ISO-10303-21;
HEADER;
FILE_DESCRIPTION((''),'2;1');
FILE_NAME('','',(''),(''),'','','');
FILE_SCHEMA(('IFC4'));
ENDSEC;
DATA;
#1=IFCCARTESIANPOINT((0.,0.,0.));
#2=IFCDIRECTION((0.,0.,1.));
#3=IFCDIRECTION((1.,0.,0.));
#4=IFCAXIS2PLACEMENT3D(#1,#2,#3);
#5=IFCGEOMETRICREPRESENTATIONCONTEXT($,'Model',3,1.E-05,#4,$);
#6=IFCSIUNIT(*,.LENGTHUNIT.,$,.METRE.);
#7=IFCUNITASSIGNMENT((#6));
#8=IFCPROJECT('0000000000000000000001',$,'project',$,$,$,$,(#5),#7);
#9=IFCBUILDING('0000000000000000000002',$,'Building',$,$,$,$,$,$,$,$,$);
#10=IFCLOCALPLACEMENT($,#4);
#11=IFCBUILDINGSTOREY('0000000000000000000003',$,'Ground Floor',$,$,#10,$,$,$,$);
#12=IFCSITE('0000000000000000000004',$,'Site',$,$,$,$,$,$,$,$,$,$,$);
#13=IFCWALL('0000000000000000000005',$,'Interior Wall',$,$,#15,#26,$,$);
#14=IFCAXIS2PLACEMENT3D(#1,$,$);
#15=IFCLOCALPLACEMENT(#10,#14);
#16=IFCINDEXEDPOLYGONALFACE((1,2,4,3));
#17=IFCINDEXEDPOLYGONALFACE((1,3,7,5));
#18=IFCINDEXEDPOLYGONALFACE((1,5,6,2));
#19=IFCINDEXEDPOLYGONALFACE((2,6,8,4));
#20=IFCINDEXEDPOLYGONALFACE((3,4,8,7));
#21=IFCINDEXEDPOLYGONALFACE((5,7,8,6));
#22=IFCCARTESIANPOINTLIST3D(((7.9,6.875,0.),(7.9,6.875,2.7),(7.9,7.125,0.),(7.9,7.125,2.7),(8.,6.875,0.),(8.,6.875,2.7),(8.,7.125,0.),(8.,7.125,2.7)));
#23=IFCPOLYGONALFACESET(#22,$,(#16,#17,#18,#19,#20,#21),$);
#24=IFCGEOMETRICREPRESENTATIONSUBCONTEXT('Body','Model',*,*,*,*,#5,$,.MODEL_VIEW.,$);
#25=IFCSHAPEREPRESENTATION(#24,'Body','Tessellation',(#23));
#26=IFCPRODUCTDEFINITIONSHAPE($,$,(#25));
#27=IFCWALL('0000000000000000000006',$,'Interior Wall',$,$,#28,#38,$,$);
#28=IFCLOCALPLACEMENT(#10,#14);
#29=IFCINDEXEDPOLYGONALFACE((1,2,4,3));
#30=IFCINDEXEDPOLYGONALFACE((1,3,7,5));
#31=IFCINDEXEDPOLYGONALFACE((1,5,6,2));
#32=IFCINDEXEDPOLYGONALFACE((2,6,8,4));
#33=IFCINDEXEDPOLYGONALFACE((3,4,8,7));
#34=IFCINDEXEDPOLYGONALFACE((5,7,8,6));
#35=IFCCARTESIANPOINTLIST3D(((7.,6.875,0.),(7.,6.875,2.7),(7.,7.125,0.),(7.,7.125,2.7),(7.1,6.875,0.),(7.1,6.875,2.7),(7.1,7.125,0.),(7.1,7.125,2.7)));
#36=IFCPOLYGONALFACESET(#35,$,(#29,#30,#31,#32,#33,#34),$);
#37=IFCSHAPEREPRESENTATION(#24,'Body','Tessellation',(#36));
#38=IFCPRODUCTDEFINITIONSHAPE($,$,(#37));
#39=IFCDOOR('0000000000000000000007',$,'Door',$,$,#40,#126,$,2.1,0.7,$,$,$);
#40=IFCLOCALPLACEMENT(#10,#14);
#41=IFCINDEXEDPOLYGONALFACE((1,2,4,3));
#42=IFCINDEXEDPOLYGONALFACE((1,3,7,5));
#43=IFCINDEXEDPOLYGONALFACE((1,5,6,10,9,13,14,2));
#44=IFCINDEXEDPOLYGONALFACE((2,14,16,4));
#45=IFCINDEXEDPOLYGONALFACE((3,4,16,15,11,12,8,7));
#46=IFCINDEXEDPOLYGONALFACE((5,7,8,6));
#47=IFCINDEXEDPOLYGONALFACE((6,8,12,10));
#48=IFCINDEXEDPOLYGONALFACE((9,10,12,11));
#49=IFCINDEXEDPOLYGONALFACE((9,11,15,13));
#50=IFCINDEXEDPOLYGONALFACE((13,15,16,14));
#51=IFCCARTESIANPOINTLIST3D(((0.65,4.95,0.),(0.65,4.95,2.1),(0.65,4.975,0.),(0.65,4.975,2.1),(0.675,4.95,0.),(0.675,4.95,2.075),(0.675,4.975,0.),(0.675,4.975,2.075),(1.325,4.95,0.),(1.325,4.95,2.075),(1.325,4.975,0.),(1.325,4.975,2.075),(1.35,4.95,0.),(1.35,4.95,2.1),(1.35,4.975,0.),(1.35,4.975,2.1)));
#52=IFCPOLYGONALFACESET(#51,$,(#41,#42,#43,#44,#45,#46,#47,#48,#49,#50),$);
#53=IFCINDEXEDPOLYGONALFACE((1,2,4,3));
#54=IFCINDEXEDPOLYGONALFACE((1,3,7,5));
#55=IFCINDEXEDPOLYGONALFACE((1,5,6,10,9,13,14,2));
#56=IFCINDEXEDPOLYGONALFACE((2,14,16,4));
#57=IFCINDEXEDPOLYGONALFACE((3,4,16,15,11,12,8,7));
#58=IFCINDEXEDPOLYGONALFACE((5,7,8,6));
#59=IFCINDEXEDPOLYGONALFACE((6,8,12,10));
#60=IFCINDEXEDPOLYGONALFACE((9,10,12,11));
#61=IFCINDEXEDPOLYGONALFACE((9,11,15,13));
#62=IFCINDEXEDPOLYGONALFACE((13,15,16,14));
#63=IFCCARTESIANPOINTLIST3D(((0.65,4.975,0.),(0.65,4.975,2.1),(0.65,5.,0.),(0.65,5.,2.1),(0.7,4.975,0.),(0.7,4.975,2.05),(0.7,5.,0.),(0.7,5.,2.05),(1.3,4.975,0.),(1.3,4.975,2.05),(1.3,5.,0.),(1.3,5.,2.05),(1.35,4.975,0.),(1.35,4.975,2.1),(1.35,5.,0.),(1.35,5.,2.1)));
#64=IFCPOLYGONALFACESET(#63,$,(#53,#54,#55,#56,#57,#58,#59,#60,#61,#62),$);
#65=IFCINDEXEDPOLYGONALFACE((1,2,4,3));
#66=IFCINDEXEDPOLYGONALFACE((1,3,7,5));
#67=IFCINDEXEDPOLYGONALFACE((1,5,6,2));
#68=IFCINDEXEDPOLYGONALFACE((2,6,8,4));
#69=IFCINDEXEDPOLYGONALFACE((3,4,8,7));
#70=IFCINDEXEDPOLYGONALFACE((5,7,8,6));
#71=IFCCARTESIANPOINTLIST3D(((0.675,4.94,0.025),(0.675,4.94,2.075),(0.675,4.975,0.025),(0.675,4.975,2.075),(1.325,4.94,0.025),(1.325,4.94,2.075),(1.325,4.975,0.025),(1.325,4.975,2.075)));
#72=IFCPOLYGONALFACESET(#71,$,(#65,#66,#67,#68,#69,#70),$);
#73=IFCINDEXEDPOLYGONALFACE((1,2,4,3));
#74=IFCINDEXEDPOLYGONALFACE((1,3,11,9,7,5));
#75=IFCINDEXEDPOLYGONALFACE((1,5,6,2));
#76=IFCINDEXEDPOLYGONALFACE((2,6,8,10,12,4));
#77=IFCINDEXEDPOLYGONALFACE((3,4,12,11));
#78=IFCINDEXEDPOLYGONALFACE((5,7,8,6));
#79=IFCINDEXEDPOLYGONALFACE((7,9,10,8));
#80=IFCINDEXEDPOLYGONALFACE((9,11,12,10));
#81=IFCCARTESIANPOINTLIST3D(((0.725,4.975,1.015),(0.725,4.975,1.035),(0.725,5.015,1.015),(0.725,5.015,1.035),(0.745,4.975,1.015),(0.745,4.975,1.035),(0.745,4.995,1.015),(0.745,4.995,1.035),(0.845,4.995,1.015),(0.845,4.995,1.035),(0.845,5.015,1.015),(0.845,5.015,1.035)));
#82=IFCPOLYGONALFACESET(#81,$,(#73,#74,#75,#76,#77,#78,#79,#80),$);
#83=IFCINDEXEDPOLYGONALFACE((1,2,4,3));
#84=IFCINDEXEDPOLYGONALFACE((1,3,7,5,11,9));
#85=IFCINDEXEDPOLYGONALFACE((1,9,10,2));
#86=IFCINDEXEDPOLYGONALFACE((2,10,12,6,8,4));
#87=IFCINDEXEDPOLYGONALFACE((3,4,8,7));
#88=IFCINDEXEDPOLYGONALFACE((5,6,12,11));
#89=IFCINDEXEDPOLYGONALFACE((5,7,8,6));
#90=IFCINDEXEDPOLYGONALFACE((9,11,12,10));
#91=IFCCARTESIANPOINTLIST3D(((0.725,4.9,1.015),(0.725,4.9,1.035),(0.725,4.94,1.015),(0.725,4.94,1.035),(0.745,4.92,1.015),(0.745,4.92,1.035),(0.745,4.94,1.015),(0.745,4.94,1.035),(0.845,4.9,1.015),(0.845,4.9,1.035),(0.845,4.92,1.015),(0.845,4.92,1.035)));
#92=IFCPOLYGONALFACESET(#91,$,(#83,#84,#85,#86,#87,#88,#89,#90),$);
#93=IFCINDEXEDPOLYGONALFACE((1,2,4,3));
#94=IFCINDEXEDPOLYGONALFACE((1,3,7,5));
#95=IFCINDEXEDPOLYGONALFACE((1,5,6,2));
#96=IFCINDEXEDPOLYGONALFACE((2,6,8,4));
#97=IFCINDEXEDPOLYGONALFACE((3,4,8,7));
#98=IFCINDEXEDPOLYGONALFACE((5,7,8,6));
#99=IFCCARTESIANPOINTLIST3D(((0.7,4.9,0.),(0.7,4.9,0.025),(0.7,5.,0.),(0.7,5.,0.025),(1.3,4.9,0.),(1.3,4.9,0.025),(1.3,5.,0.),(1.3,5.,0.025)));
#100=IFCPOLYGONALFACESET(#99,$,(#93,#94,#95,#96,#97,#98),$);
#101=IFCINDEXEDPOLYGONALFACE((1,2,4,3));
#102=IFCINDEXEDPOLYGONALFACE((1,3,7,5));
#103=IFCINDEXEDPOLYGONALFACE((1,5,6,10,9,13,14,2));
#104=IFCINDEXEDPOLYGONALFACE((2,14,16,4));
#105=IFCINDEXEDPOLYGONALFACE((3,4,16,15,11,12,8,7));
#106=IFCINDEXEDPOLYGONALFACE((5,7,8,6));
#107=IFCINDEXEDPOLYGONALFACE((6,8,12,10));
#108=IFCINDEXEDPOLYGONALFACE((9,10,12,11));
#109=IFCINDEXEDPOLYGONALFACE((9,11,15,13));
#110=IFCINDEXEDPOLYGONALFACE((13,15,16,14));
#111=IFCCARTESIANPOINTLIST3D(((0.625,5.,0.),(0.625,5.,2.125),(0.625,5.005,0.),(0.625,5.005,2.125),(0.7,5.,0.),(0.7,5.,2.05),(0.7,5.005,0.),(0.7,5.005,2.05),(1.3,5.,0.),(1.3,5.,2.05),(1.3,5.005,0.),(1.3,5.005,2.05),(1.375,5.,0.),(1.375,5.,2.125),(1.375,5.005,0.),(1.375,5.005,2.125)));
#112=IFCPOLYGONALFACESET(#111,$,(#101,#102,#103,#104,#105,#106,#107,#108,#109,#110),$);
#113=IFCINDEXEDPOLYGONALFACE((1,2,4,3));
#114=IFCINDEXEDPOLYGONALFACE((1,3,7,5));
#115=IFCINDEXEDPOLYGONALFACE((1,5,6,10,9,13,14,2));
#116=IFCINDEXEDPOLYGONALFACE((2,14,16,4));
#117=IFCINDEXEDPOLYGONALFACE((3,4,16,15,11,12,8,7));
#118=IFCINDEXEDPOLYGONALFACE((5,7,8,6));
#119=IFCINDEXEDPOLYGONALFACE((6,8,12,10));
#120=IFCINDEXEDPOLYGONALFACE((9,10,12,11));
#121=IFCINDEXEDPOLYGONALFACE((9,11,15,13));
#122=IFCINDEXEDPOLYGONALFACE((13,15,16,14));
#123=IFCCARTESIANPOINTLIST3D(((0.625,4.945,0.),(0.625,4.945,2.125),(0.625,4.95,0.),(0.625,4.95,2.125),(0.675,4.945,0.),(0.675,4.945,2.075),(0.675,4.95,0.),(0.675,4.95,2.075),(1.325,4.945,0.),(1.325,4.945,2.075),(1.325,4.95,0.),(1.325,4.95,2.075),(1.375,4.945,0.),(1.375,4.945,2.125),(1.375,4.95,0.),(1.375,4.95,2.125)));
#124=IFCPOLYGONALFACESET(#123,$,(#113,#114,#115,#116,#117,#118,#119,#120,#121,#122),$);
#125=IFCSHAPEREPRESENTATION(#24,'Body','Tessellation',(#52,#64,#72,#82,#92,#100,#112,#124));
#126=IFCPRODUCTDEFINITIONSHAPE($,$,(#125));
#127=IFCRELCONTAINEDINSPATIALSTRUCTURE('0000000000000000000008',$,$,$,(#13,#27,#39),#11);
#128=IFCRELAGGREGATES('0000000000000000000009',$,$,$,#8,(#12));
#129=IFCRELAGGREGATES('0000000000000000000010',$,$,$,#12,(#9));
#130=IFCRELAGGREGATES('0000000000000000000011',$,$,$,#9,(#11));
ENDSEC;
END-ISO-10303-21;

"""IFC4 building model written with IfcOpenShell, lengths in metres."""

from ifc_helpers import new_model, si_unit, frame, origin_with_axes, place, context, subcontext, project, spatial, line, indexed_curve, outline, extrude, element, save


model = new_model("IFC4")

# Units and contexts
model_context = context("Model", 3, precision=1e-05, world=origin_with_axes())
body_context = subcontext(model_context, "Body", "Model", "MODEL_VIEW")
ifc_project = project(units=[si_unit("LENGTHUNIT", "METRE")], contexts=[model_context])

# Site, building, storey
site = spatial("IfcSite", under=ifc_project, Name="Site")
building = spatial("IfcBuilding", under=site, Name="Building")
storey_placement = place(None, origin_with_axes())
storey = spatial("IfcBuildingStorey", under=building, at=storey_placement, Name="Ground Floor")

# Walls
for number, where, z_axis, x_axis, name in (
    (1, (8.0, 7.0, 0.0), (0.0, 0.0, 1.0), (-1.0, 0.0, 0.0), "Interior Wall"),
    (2, (7.1, 7.0, 0.0), (0.0, 0.0, 1.0), (-1.0, 0.0, 0.0), "Interior Wall"),
):
    element("IfcWall", number, at=place(storey_placement, frame(where, z_axis=z_axis, x_axis=x_axis)), inside=storey, Name=name, context=body_context, shape_type="SweptSolid", body=[
        extrude(outline(indexed_curve([(0.0, 0.0), (0.0, 0.25), (0.1, 0.25), (0.1, 0.0), (0.0, 0.0)], self_intersect=False)), frame((0.0, -0.125, 0.0), z_axis=(0.0, 0.0, 1.0), x_axis=(1.0, 0.0, 0.0)), (0.0, 0.0, 1.0), 2.7),
    ])

# Door
door_1_placement = place(storey_placement, frame((1.35, 5.0, 0.0), z_axis=(0.0, 0.0, 1.0), x_axis=(-1.0, 0.0, 0.0)))
element("IfcDoor", 3, at=door_1_placement, inside=storey, Name="Door", OverallHeight=2.1, OverallWidth=0.7, context=body_context, shape_type="SweptSolid", body=[
    extrude(outline(indexed_curve([(0.0, 0.0), (0.0, 2.1), (0.7, 2.1), (0.7, 0.0), (0.675, 0.0), (0.675, 2.075), (0.025, 2.075), (0.025, 0.0)], segments=[line(1, 2, 3, 4, 5, 6, 7, 8, 1)])), frame((0.0, 0.025, 0.0), z_axis=(0.0, -1.0, 0.0), x_axis=(1.0, 0.0, 0.0)), (0.0, 0.0, -1.0), 0.025),
    extrude(outline(indexed_curve([(0.0, 0.0), (0.0, 2.1), (0.7, 2.1), (0.7, 0.0), (0.65, 0.0), (0.65, 2.05), (0.05, 2.05), (0.05, 0.0)], segments=[line(1, 2, 3, 4, 5, 6, 7, 8, 1)])), frame((0.0, 0.0, 0.0), z_axis=(0.0, -1.0, 0.0), x_axis=(1.0, 0.0, 0.0)), (0.0, 0.0, -1.0), 0.025),
    extrude(outline(indexed_curve([(0.0, 0.0), (0.65, 0.0), (0.65, 0.035), (0.0, 0.035)], segments=[line(1, 2, 3, 4, 1)])), frame((0.025, 0.025, 0.025), z_axis=(0.0, 0.0, 1.0), x_axis=(1.0, 0.0, 0.0)), (0.0, 0.0, 1.0), 2.05),
    extrude(outline(indexed_curve([(0.0, 0.0), (0.0, -0.04), (-0.12, -0.04), (-0.12, -0.02), (-0.02, -0.02), (-0.02, 0.0)], segments=[line(1, 2, 3, 4, 5, 6, 1)])), frame((0.625, 0.025, 1.015), z_axis=(0.0, 0.0, 1.0), x_axis=(1.0, 0.0, 0.0)), (0.0, 0.0, 1.0), 0.02),
    extrude(outline(indexed_curve([(0.0, 0.0), (0.0, 0.04), (-0.12, 0.04), (-0.12, 0.02), (-0.02, 0.02), (-0.02, 0.0)], segments=[line(1, 2, 3, 4, 5, 6, 1)])), frame((0.625, 0.06, 1.015), z_axis=(0.0, 0.0, 1.0), x_axis=(1.0, 0.0, 0.0)), (0.0, 0.0, 1.0), 0.02),
    extrude(outline(indexed_curve([(0.0, 0.0), (0.6, 0.0), (0.6, 0.1), (0.0, 0.1)], segments=[line(1, 2, 3, 4, 1)])), frame((0.05, 0.0, 0.0), z_axis=(0.0, 0.0, 1.0), x_axis=(1.0, 0.0, 0.0)), (0.0, 0.0, 1.0), 0.025),
    extrude(outline(indexed_curve([(0.0, 0.0), (0.0, 2.125), (0.75, 2.125), (0.75, 0.0), (0.675, 0.0), (0.675, 2.05), (0.075, 2.05), (0.075, 0.0)], segments=[line(1, 2, 3, 4, 5, 6, 7, 8, 1)])), frame((-0.025, -0.005, 0.0), z_axis=(0.0, -1.0, 0.0), x_axis=(1.0, 0.0, 0.0)), (0.0, 0.0, -1.0), 0.005),
    extrude(outline(indexed_curve([(0.0, 0.0), (0.0, 2.125), (0.75, 2.125), (0.75, 0.0), (0.7, 0.0), (0.7, 2.075), (0.05, 2.075), (0.05, 0.0)], segments=[line(1, 2, 3, 4, 5, 6, 7, 8, 1)])), frame((-0.025, 0.05, 0.0), z_axis=(0.0, -1.0, 0.0), x_axis=(1.0, 0.0, 0.0)), (0.0, 0.0, -1.0), 0.005),
])

save(model, "model.ifc")
